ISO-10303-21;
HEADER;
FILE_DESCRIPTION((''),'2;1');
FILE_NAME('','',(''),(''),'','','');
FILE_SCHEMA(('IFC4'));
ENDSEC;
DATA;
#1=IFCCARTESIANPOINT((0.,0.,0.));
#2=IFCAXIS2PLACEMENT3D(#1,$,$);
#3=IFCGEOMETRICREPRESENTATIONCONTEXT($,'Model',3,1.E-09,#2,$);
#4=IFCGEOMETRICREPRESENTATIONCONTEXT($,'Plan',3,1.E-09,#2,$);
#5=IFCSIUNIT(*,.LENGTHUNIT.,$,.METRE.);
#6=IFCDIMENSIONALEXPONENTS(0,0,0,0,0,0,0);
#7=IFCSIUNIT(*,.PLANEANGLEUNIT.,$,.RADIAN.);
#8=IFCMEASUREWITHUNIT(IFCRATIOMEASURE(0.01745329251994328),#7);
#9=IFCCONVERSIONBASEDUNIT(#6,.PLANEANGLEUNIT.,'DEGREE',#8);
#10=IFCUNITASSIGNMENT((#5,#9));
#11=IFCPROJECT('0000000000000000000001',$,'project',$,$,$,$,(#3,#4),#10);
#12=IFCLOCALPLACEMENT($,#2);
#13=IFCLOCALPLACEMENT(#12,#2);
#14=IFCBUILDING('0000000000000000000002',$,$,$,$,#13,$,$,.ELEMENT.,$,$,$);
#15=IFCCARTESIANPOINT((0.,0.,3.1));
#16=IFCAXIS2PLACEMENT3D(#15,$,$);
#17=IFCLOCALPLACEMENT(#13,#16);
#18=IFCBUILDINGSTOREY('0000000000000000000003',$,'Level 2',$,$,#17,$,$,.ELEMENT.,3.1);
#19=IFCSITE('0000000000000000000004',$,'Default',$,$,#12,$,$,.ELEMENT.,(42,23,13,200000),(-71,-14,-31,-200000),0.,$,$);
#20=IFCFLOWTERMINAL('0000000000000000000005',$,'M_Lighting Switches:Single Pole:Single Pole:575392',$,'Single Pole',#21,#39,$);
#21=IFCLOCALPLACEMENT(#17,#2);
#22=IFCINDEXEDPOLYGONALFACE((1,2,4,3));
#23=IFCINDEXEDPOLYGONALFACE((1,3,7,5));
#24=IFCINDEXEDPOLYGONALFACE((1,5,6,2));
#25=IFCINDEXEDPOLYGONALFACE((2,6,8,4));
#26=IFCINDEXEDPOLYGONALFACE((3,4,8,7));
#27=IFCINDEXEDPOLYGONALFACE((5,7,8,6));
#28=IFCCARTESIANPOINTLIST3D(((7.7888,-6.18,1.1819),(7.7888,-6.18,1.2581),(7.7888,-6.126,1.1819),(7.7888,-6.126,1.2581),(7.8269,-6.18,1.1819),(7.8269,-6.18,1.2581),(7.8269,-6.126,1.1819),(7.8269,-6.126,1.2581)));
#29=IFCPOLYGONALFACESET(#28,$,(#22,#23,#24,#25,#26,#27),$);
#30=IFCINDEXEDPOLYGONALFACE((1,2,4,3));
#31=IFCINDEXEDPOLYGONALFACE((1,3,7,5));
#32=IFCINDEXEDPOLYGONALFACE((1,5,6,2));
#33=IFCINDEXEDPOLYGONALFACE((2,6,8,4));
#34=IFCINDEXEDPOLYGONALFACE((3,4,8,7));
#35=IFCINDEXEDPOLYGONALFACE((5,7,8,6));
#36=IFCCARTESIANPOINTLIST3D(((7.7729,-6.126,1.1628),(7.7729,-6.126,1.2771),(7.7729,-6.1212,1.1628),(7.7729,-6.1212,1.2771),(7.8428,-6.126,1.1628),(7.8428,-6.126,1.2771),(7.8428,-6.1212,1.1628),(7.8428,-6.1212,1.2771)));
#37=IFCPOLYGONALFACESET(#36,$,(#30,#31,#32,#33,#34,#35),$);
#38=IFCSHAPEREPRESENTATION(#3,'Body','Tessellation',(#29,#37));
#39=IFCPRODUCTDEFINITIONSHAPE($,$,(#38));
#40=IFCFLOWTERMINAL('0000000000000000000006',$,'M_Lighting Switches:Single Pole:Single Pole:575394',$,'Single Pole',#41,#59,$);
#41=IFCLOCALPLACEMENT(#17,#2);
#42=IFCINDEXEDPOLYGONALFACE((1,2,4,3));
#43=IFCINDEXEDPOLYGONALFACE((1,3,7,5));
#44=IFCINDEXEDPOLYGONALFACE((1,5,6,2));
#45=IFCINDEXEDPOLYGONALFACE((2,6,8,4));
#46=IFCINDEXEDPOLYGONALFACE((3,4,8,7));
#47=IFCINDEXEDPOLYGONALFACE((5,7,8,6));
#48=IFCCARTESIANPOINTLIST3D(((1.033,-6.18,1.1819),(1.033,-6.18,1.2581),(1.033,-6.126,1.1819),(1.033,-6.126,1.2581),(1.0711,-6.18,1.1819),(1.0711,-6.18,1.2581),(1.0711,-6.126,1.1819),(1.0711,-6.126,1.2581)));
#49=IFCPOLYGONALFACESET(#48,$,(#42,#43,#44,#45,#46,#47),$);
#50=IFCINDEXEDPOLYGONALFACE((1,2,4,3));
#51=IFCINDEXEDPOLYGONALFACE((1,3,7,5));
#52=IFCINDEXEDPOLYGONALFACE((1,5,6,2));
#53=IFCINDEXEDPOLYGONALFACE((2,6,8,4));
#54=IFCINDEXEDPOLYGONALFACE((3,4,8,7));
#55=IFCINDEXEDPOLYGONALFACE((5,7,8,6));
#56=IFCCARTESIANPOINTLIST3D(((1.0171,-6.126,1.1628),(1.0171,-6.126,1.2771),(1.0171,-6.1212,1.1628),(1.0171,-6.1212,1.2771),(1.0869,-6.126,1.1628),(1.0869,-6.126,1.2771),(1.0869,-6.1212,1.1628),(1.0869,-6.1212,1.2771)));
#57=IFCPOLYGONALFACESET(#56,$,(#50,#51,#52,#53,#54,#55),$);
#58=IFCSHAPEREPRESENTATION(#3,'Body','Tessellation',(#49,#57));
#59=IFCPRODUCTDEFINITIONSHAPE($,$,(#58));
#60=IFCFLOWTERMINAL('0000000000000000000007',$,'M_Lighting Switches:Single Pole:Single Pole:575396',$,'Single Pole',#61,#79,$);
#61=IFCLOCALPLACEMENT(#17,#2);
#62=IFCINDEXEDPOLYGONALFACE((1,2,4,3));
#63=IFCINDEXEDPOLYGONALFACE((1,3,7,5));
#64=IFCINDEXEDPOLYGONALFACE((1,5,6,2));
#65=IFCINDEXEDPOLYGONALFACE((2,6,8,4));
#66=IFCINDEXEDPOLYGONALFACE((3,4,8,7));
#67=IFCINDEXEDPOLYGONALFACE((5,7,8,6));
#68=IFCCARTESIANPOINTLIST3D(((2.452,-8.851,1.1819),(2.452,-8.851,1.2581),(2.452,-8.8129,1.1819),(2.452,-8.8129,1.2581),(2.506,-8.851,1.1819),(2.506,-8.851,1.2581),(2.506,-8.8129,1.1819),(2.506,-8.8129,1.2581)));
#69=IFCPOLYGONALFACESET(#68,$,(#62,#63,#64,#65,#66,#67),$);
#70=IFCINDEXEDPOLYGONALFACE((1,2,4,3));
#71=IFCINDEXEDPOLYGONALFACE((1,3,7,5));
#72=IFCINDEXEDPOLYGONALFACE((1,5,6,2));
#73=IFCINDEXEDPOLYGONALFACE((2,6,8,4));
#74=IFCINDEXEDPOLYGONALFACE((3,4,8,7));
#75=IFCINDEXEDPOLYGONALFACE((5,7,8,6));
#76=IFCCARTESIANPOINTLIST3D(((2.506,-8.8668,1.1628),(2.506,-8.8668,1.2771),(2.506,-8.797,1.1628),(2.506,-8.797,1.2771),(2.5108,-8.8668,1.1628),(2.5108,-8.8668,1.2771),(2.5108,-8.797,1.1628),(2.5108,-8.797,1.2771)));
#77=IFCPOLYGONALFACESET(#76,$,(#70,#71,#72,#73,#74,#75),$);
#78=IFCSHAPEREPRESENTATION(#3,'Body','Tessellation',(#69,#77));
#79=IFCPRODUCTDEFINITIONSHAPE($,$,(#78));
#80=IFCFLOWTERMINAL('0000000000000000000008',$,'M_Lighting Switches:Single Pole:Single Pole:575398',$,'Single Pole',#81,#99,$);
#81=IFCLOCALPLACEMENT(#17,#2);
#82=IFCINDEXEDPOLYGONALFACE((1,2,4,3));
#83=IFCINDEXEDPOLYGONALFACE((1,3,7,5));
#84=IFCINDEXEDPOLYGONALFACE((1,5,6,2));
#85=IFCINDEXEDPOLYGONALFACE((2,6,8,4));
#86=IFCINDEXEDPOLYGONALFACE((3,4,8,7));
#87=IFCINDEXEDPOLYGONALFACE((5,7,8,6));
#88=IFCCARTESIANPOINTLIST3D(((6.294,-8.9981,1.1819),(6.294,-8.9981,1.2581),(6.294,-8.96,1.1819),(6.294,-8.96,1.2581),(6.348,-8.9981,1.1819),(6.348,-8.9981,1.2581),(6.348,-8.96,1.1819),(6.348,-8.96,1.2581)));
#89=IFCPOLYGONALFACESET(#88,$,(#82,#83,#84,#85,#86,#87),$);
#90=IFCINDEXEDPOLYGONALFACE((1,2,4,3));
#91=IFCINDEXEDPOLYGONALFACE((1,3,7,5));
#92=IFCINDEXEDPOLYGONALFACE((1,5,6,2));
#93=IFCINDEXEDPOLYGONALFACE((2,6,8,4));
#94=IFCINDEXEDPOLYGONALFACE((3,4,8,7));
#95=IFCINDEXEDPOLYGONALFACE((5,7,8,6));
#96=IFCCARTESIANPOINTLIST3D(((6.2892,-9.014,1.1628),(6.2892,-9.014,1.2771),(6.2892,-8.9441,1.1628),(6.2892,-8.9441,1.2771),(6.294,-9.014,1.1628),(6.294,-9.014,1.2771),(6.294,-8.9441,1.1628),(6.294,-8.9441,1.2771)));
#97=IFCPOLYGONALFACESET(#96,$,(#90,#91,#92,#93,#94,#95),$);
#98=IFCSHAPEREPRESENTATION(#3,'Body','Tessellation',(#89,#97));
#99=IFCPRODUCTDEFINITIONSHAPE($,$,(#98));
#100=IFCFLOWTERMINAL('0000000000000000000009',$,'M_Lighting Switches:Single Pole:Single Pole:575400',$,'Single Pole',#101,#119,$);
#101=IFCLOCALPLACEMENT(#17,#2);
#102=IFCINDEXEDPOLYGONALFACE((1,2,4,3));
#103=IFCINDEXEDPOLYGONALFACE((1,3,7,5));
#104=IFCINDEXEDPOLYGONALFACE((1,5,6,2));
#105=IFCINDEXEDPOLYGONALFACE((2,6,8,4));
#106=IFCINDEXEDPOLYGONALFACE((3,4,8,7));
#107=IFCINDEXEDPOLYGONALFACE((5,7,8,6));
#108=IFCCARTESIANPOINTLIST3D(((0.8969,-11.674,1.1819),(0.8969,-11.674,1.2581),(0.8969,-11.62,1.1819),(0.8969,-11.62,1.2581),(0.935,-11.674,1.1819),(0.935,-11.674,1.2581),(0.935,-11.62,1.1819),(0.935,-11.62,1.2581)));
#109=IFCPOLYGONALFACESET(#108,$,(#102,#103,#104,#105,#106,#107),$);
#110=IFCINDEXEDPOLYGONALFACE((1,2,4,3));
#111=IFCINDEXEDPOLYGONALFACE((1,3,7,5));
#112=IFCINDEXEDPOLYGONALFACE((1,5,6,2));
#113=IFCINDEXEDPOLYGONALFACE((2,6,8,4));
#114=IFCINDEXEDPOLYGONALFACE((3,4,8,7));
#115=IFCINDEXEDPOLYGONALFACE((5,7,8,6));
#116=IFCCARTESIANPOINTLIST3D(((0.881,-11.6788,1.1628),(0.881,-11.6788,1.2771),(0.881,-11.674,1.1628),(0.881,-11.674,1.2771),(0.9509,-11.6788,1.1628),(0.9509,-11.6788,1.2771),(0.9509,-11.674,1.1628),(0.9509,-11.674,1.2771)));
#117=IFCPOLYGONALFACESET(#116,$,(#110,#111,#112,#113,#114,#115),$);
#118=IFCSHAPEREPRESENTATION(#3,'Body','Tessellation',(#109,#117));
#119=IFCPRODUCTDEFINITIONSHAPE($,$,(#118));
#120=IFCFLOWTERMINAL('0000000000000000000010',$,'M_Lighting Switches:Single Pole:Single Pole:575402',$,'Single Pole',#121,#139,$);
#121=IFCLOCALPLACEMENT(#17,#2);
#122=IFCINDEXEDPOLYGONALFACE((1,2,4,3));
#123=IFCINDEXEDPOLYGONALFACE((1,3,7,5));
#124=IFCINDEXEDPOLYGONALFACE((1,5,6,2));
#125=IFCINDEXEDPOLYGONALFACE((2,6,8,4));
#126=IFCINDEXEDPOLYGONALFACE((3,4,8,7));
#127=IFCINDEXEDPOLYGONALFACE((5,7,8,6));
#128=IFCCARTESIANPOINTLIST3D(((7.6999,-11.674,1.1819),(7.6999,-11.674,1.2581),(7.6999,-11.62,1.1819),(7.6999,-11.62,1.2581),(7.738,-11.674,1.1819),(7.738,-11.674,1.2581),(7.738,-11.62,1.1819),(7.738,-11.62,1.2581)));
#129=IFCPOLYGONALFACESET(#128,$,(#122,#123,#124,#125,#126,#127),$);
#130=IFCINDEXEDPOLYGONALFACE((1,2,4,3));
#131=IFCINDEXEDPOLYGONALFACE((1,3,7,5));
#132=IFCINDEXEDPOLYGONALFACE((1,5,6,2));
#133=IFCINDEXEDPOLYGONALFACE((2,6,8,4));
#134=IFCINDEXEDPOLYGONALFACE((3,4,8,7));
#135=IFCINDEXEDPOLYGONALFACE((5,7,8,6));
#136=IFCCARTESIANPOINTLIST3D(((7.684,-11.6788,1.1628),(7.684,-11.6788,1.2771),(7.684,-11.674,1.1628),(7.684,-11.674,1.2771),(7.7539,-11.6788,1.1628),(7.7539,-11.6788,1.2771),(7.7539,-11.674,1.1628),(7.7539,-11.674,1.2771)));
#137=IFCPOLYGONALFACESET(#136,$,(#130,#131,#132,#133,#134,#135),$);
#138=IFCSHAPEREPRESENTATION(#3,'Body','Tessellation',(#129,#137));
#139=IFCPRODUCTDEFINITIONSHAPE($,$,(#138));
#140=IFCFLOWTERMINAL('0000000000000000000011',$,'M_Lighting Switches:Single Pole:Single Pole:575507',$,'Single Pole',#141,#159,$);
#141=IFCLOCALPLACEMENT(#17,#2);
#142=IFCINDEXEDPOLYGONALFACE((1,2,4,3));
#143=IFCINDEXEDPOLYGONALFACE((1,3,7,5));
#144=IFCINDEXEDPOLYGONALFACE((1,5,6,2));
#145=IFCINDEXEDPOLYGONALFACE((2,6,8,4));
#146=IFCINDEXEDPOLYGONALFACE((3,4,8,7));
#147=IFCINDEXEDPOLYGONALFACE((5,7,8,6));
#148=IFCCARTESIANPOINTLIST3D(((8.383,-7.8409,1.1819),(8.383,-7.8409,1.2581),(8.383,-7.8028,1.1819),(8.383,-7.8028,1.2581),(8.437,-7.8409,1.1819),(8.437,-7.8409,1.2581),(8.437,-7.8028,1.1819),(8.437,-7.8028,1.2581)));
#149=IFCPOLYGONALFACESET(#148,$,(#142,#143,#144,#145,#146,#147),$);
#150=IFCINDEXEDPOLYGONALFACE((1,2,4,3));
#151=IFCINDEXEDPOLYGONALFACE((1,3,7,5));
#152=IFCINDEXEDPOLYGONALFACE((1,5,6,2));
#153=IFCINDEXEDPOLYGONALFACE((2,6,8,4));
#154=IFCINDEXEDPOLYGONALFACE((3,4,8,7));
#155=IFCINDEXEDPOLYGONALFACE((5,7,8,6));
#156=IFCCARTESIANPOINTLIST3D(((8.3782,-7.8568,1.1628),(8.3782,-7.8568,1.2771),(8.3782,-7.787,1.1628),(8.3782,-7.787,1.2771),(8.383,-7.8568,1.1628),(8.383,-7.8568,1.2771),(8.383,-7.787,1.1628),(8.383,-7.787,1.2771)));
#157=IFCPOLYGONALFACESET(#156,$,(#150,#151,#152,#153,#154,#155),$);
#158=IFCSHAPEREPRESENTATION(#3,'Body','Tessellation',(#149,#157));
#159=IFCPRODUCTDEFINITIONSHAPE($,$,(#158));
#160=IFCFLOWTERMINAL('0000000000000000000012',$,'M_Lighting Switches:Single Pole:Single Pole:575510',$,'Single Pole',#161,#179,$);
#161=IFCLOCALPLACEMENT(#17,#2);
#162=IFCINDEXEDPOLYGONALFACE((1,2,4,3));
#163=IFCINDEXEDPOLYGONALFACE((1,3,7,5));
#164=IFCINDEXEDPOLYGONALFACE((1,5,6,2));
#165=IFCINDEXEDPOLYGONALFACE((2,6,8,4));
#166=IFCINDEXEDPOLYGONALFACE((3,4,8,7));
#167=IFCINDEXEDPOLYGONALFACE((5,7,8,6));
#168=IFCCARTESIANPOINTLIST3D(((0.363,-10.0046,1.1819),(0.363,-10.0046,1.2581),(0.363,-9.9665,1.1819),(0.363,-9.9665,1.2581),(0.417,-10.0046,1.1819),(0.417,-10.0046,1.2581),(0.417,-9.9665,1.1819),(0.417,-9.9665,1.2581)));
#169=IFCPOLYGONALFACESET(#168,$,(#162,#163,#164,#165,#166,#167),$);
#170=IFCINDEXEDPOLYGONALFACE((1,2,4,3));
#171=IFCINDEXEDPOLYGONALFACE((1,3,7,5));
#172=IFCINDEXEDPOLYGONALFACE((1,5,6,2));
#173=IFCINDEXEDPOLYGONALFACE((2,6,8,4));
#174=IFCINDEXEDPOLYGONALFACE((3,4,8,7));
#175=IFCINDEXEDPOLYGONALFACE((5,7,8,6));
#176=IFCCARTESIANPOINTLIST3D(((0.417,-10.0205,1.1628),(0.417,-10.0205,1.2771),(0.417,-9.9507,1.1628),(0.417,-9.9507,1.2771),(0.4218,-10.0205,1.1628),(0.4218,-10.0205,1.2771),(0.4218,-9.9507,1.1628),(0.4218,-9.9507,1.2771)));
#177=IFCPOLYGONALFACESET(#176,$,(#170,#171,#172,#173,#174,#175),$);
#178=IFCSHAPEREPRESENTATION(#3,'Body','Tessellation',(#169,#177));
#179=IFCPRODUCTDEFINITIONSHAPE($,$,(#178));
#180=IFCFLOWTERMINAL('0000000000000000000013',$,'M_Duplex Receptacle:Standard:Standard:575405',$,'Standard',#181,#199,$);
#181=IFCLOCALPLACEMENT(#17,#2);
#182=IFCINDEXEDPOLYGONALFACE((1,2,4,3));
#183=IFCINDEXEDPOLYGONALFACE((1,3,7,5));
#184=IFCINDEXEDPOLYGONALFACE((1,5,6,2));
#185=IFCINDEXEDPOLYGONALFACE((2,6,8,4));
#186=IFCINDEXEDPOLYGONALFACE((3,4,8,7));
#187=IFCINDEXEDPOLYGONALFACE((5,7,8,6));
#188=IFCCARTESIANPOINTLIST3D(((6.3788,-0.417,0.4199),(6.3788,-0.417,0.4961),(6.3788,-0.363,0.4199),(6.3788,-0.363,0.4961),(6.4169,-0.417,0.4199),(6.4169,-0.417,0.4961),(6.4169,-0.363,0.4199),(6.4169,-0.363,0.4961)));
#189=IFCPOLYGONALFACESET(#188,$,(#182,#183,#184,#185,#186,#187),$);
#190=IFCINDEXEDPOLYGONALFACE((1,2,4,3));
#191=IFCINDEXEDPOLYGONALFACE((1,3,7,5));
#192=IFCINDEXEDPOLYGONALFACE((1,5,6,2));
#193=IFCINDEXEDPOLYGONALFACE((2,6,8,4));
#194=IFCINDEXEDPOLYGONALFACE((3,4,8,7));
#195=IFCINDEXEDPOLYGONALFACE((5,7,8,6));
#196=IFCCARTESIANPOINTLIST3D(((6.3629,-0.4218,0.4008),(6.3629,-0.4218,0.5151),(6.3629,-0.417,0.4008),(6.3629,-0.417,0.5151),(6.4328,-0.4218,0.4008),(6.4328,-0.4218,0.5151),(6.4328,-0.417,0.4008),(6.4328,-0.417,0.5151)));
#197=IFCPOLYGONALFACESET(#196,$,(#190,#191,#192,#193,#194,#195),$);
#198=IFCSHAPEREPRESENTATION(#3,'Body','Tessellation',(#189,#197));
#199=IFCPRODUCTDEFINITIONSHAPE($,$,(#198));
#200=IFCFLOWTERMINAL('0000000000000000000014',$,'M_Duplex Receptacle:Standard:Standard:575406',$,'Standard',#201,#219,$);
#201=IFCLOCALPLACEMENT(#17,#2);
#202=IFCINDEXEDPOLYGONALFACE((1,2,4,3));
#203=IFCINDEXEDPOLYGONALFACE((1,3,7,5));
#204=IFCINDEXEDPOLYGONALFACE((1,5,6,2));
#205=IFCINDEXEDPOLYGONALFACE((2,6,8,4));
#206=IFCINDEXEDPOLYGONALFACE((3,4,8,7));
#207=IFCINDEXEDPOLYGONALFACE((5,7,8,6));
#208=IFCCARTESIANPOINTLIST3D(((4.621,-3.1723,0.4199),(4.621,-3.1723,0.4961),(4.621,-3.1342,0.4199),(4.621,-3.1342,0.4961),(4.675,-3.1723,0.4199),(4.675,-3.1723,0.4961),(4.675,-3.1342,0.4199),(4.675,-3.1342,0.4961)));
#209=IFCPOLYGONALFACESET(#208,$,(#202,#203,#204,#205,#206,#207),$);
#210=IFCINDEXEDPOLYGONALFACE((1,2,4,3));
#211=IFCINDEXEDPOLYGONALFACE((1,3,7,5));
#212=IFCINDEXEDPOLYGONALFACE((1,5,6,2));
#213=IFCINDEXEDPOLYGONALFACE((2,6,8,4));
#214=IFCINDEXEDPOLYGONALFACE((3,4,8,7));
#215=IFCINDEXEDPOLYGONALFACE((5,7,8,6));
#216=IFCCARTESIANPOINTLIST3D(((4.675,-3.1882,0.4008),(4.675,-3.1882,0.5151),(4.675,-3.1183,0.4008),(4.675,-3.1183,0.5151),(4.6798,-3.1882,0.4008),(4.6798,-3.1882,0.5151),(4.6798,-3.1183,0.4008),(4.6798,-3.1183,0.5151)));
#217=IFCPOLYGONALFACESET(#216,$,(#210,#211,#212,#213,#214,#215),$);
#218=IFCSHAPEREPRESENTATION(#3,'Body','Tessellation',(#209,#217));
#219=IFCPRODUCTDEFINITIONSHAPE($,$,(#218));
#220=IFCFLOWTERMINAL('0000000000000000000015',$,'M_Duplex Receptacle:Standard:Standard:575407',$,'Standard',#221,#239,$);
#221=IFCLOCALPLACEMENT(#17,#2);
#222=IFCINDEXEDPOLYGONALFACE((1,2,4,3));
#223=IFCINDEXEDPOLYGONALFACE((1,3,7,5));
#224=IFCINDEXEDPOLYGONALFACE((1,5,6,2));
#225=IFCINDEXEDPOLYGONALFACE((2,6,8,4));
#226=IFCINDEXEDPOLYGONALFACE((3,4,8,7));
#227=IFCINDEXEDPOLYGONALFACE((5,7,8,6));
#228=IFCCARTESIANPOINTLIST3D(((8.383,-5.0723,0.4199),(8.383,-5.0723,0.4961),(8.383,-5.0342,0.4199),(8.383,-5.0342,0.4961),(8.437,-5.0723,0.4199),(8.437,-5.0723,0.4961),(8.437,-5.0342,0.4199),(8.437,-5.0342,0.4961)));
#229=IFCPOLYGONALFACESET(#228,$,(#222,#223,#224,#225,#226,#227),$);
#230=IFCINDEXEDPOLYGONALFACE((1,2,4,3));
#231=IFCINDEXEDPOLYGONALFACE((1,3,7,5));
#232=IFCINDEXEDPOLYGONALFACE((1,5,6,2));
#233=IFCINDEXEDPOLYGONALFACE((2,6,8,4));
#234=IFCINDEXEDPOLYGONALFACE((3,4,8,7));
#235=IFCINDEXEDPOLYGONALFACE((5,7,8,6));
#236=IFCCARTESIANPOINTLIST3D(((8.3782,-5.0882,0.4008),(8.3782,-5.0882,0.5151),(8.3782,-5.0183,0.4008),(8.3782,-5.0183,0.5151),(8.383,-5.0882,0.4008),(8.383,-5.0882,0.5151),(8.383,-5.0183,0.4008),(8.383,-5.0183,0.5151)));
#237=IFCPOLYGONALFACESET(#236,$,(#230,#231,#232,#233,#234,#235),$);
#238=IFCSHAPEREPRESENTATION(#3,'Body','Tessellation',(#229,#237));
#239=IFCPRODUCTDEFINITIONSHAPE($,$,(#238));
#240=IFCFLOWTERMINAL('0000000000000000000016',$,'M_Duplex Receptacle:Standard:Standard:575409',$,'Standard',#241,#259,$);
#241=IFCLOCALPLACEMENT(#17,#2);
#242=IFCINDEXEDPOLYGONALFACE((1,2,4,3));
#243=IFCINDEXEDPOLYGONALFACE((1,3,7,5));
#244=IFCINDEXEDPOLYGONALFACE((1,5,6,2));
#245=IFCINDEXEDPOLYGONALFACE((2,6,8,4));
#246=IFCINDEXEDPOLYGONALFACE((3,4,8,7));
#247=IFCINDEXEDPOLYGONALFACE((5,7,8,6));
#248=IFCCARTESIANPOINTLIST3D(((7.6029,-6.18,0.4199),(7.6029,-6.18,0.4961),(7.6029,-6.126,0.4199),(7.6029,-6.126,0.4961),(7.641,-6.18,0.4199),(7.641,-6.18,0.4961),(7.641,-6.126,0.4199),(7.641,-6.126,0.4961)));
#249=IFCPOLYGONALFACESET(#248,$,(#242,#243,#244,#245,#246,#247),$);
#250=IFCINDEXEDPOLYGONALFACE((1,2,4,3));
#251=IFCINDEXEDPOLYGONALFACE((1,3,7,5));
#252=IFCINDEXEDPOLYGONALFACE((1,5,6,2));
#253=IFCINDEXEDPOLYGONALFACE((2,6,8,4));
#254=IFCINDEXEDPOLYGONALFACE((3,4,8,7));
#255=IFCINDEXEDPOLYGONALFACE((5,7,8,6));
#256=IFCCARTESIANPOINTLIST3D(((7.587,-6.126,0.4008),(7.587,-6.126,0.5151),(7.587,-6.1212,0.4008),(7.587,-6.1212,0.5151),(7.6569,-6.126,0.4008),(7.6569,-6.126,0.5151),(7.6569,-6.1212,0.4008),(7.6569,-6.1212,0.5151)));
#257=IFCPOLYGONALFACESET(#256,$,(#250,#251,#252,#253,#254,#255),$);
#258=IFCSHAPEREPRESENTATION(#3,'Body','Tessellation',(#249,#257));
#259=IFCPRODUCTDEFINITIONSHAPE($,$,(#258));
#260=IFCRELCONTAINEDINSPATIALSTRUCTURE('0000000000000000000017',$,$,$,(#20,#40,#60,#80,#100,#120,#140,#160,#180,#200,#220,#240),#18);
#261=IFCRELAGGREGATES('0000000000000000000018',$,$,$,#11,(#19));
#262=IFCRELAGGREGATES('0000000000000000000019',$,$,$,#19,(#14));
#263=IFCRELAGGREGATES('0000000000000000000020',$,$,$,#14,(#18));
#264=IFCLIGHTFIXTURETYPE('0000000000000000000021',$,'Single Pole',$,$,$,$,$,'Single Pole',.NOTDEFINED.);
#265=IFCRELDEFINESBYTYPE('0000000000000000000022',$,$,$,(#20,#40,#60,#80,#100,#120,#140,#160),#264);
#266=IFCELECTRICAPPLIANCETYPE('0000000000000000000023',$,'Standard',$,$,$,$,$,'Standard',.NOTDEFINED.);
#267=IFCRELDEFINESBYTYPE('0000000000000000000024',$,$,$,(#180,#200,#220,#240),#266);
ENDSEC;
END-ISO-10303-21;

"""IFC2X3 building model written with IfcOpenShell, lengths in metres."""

from ifc_helpers import new_model, entity, si_unit, converted_unit, frame, origin, origin_2d_with_axis, place, context, project, spatial, rectangle, extrude, source, transform, mapped, type_object, type_shapes, element, save


model = new_model("IFC2X3")

# Units and contexts
model_context = context("Model", 3, precision=1e-09, world=origin())
plan_context = context("Plan", 3, precision=1e-09, world=origin())
ifc_project = project(units=[si_unit("LENGTHUNIT", "METRE"), converted_unit("PLANEANGLEUNIT", "DEGREE", entity("IfcRatioMeasure", 0.01745329251994328), si_unit("PLANEANGLEUNIT", "RADIAN"), dimensions=[0, 0, 0, 0, 0, 0, 0])], contexts=[model_context, plan_context])

# Site, building, storey
site_placement = place(None, origin())
site = spatial("IfcSite", under=ifc_project, at=site_placement, Name="Default", CompositionType="ELEMENT", RefLatitude=(42, 23, 13, 200000), RefLongitude=(-71, -14, -31, -200000), RefElevation=0.0)
building_placement = place(site_placement, origin())
building = spatial("IfcBuilding", under=site, at=building_placement, CompositionType="ELEMENT")
storey_placement = place(building_placement, frame((0.0, 0.0, 3.1)))
storey = spatial("IfcBuildingStorey", under=building, at=storey_placement, Name="Level 2", CompositionType="ELEMENT", Elevation=3.1)

# Flow terminals
light_fixture_type = type_object("IfcLightFixtureType", Name="Single Pole", ElementType="Single Pole", PredefinedType="NOTDEFINED")
shared_shape_1 = source(origin(), model_context, "Body", "SweptSolid", [
    extrude(rectangle(XDim=0.0381, YDim=0.0762, at=origin_2d_with_axis()), frame((0.0, 0.0, -0.054), z_axis=(0.0, 0.0, 1.0), x_axis=(-1.0, 0.0, 0.0)), (0.0, 0.0, 1.0), 0.054),
    extrude(rectangle(XDim=0.0698, YDim=0.1143, at=origin_2d_with_axis()), frame((0.0, 0.0, 0.0), z_axis=(0.0, 0.0, 1.0), x_axis=(-1.0, 0.0, 0.0)), (0.0, 0.0, 1.0), 0.0048),
])
type_shapes(light_fixture_type, [shared_shape_1])
for number, where, z_axis, x_axis, name in (
    (1, (7.8079, -6.126, 1.22), (0.0, 1.0, 0.0), (-1.0, 0.0, 0.0), "M_Lighting Switches:Single Pole:Single Pole:575392"),
    (2, (1.052, -6.126, 1.22), (0.0, 1.0, 0.0), (-1.0, 0.0, 0.0), "M_Lighting Switches:Single Pole:Single Pole:575394"),
    (3, (2.506, -8.8319, 1.22), (1.0, 0.0, 0.0), (0.0, 1.0, 0.0), "M_Lighting Switches:Single Pole:Single Pole:575396"),
    (4, (6.294, -8.9791, 1.22), (-1.0, 0.0, 0.0), (0.0, -1.0, 0.0), "M_Lighting Switches:Single Pole:Single Pole:575398"),
    (5, (0.916, -11.674, 1.22), (0.0, -1.0, 0.0), (1.0, 0.0, 0.0), "M_Lighting Switches:Single Pole:Single Pole:575400"),
    (6, (7.719, -11.674, 1.22), (0.0, -1.0, 0.0), (1.0, 0.0, 0.0), "M_Lighting Switches:Single Pole:Single Pole:575402"),
    (7, (8.383, -7.8219, 1.22), (-1.0, 0.0, 0.0), (0.0, -1.0, 0.0), "M_Lighting Switches:Single Pole:Single Pole:575507"),
    (8, (0.417, -9.9856, 1.22), (1.0, 0.0, 0.0), (0.0, 1.0, 0.0), "M_Lighting Switches:Single Pole:Single Pole:575510"),
):
    element("IfcFlowTerminal", number, at=place(storey_placement, frame(where, z_axis=z_axis, x_axis=x_axis)), inside=storey, type_object=light_fixture_type, Name=name, ObjectType="Single Pole", context=model_context, shape_type="MappedRepresentation", body=[
        mapped(shared_shape_1, transform((0.0, 0.0, 0.0), scale=1.0)),
    ])
electric_appliance_type_1 = type_object("IfcElectricApplianceType", Name="Standard", ElementType="Standard", PredefinedType="NOTDEFINED")
shared_shape_2 = source(origin(), model_context, "Body", "SweptSolid", [
    extrude(rectangle(XDim=0.0381, YDim=0.0762, at=origin_2d_with_axis()), frame((0.0, 0.0, -0.054), z_axis=(0.0, 0.0, 1.0), x_axis=(-1.0, 0.0, 0.0)), (0.0, 0.0, 1.0), 0.054),
    extrude(rectangle(XDim=0.0698, YDim=0.1143, at=origin_2d_with_axis()), frame((0.0, 0.0, 0.0), z_axis=(0.0, 0.0, 1.0), x_axis=(-1.0, 0.0, 0.0)), (0.0, 0.0, 1.0), 0.0048),
])
type_shapes(electric_appliance_type_1, [shared_shape_2])
for number, where, z_axis, x_axis, name in (
    (9, (6.3979, -0.417, 0.458), (0.0, -1.0, 0.0), (1.0, 0.0, 0.0), "M_Duplex Receptacle:Standard:Standard:575405"),
    (10, (4.675, -3.1533, 0.458), (1.0, 0.0, 0.0), (0.0, 1.0, 0.0), "M_Duplex Receptacle:Standard:Standard:575406"),
    (11, (8.383, -5.0533, 0.458), (-1.0, 0.0, 0.0), (0.0, -1.0, 0.0), "M_Duplex Receptacle:Standard:Standard:575407"),
    (12, (7.622, -6.126, 0.458), (0.0, 1.0, 0.0), (-1.0, 0.0, 0.0), "M_Duplex Receptacle:Standard:Standard:575409"),
):
    element("IfcFlowTerminal", number, at=place(storey_placement, frame(where, z_axis=z_axis, x_axis=x_axis)), inside=storey, type_object=electric_appliance_type_1, Name=name, ObjectType="Standard", context=model_context, shape_type="MappedRepresentation", body=[
        mapped(shared_shape_2, transform((0.0, 0.0, 0.0), scale=1.0)),
    ])

save(model, "model.ifc")
